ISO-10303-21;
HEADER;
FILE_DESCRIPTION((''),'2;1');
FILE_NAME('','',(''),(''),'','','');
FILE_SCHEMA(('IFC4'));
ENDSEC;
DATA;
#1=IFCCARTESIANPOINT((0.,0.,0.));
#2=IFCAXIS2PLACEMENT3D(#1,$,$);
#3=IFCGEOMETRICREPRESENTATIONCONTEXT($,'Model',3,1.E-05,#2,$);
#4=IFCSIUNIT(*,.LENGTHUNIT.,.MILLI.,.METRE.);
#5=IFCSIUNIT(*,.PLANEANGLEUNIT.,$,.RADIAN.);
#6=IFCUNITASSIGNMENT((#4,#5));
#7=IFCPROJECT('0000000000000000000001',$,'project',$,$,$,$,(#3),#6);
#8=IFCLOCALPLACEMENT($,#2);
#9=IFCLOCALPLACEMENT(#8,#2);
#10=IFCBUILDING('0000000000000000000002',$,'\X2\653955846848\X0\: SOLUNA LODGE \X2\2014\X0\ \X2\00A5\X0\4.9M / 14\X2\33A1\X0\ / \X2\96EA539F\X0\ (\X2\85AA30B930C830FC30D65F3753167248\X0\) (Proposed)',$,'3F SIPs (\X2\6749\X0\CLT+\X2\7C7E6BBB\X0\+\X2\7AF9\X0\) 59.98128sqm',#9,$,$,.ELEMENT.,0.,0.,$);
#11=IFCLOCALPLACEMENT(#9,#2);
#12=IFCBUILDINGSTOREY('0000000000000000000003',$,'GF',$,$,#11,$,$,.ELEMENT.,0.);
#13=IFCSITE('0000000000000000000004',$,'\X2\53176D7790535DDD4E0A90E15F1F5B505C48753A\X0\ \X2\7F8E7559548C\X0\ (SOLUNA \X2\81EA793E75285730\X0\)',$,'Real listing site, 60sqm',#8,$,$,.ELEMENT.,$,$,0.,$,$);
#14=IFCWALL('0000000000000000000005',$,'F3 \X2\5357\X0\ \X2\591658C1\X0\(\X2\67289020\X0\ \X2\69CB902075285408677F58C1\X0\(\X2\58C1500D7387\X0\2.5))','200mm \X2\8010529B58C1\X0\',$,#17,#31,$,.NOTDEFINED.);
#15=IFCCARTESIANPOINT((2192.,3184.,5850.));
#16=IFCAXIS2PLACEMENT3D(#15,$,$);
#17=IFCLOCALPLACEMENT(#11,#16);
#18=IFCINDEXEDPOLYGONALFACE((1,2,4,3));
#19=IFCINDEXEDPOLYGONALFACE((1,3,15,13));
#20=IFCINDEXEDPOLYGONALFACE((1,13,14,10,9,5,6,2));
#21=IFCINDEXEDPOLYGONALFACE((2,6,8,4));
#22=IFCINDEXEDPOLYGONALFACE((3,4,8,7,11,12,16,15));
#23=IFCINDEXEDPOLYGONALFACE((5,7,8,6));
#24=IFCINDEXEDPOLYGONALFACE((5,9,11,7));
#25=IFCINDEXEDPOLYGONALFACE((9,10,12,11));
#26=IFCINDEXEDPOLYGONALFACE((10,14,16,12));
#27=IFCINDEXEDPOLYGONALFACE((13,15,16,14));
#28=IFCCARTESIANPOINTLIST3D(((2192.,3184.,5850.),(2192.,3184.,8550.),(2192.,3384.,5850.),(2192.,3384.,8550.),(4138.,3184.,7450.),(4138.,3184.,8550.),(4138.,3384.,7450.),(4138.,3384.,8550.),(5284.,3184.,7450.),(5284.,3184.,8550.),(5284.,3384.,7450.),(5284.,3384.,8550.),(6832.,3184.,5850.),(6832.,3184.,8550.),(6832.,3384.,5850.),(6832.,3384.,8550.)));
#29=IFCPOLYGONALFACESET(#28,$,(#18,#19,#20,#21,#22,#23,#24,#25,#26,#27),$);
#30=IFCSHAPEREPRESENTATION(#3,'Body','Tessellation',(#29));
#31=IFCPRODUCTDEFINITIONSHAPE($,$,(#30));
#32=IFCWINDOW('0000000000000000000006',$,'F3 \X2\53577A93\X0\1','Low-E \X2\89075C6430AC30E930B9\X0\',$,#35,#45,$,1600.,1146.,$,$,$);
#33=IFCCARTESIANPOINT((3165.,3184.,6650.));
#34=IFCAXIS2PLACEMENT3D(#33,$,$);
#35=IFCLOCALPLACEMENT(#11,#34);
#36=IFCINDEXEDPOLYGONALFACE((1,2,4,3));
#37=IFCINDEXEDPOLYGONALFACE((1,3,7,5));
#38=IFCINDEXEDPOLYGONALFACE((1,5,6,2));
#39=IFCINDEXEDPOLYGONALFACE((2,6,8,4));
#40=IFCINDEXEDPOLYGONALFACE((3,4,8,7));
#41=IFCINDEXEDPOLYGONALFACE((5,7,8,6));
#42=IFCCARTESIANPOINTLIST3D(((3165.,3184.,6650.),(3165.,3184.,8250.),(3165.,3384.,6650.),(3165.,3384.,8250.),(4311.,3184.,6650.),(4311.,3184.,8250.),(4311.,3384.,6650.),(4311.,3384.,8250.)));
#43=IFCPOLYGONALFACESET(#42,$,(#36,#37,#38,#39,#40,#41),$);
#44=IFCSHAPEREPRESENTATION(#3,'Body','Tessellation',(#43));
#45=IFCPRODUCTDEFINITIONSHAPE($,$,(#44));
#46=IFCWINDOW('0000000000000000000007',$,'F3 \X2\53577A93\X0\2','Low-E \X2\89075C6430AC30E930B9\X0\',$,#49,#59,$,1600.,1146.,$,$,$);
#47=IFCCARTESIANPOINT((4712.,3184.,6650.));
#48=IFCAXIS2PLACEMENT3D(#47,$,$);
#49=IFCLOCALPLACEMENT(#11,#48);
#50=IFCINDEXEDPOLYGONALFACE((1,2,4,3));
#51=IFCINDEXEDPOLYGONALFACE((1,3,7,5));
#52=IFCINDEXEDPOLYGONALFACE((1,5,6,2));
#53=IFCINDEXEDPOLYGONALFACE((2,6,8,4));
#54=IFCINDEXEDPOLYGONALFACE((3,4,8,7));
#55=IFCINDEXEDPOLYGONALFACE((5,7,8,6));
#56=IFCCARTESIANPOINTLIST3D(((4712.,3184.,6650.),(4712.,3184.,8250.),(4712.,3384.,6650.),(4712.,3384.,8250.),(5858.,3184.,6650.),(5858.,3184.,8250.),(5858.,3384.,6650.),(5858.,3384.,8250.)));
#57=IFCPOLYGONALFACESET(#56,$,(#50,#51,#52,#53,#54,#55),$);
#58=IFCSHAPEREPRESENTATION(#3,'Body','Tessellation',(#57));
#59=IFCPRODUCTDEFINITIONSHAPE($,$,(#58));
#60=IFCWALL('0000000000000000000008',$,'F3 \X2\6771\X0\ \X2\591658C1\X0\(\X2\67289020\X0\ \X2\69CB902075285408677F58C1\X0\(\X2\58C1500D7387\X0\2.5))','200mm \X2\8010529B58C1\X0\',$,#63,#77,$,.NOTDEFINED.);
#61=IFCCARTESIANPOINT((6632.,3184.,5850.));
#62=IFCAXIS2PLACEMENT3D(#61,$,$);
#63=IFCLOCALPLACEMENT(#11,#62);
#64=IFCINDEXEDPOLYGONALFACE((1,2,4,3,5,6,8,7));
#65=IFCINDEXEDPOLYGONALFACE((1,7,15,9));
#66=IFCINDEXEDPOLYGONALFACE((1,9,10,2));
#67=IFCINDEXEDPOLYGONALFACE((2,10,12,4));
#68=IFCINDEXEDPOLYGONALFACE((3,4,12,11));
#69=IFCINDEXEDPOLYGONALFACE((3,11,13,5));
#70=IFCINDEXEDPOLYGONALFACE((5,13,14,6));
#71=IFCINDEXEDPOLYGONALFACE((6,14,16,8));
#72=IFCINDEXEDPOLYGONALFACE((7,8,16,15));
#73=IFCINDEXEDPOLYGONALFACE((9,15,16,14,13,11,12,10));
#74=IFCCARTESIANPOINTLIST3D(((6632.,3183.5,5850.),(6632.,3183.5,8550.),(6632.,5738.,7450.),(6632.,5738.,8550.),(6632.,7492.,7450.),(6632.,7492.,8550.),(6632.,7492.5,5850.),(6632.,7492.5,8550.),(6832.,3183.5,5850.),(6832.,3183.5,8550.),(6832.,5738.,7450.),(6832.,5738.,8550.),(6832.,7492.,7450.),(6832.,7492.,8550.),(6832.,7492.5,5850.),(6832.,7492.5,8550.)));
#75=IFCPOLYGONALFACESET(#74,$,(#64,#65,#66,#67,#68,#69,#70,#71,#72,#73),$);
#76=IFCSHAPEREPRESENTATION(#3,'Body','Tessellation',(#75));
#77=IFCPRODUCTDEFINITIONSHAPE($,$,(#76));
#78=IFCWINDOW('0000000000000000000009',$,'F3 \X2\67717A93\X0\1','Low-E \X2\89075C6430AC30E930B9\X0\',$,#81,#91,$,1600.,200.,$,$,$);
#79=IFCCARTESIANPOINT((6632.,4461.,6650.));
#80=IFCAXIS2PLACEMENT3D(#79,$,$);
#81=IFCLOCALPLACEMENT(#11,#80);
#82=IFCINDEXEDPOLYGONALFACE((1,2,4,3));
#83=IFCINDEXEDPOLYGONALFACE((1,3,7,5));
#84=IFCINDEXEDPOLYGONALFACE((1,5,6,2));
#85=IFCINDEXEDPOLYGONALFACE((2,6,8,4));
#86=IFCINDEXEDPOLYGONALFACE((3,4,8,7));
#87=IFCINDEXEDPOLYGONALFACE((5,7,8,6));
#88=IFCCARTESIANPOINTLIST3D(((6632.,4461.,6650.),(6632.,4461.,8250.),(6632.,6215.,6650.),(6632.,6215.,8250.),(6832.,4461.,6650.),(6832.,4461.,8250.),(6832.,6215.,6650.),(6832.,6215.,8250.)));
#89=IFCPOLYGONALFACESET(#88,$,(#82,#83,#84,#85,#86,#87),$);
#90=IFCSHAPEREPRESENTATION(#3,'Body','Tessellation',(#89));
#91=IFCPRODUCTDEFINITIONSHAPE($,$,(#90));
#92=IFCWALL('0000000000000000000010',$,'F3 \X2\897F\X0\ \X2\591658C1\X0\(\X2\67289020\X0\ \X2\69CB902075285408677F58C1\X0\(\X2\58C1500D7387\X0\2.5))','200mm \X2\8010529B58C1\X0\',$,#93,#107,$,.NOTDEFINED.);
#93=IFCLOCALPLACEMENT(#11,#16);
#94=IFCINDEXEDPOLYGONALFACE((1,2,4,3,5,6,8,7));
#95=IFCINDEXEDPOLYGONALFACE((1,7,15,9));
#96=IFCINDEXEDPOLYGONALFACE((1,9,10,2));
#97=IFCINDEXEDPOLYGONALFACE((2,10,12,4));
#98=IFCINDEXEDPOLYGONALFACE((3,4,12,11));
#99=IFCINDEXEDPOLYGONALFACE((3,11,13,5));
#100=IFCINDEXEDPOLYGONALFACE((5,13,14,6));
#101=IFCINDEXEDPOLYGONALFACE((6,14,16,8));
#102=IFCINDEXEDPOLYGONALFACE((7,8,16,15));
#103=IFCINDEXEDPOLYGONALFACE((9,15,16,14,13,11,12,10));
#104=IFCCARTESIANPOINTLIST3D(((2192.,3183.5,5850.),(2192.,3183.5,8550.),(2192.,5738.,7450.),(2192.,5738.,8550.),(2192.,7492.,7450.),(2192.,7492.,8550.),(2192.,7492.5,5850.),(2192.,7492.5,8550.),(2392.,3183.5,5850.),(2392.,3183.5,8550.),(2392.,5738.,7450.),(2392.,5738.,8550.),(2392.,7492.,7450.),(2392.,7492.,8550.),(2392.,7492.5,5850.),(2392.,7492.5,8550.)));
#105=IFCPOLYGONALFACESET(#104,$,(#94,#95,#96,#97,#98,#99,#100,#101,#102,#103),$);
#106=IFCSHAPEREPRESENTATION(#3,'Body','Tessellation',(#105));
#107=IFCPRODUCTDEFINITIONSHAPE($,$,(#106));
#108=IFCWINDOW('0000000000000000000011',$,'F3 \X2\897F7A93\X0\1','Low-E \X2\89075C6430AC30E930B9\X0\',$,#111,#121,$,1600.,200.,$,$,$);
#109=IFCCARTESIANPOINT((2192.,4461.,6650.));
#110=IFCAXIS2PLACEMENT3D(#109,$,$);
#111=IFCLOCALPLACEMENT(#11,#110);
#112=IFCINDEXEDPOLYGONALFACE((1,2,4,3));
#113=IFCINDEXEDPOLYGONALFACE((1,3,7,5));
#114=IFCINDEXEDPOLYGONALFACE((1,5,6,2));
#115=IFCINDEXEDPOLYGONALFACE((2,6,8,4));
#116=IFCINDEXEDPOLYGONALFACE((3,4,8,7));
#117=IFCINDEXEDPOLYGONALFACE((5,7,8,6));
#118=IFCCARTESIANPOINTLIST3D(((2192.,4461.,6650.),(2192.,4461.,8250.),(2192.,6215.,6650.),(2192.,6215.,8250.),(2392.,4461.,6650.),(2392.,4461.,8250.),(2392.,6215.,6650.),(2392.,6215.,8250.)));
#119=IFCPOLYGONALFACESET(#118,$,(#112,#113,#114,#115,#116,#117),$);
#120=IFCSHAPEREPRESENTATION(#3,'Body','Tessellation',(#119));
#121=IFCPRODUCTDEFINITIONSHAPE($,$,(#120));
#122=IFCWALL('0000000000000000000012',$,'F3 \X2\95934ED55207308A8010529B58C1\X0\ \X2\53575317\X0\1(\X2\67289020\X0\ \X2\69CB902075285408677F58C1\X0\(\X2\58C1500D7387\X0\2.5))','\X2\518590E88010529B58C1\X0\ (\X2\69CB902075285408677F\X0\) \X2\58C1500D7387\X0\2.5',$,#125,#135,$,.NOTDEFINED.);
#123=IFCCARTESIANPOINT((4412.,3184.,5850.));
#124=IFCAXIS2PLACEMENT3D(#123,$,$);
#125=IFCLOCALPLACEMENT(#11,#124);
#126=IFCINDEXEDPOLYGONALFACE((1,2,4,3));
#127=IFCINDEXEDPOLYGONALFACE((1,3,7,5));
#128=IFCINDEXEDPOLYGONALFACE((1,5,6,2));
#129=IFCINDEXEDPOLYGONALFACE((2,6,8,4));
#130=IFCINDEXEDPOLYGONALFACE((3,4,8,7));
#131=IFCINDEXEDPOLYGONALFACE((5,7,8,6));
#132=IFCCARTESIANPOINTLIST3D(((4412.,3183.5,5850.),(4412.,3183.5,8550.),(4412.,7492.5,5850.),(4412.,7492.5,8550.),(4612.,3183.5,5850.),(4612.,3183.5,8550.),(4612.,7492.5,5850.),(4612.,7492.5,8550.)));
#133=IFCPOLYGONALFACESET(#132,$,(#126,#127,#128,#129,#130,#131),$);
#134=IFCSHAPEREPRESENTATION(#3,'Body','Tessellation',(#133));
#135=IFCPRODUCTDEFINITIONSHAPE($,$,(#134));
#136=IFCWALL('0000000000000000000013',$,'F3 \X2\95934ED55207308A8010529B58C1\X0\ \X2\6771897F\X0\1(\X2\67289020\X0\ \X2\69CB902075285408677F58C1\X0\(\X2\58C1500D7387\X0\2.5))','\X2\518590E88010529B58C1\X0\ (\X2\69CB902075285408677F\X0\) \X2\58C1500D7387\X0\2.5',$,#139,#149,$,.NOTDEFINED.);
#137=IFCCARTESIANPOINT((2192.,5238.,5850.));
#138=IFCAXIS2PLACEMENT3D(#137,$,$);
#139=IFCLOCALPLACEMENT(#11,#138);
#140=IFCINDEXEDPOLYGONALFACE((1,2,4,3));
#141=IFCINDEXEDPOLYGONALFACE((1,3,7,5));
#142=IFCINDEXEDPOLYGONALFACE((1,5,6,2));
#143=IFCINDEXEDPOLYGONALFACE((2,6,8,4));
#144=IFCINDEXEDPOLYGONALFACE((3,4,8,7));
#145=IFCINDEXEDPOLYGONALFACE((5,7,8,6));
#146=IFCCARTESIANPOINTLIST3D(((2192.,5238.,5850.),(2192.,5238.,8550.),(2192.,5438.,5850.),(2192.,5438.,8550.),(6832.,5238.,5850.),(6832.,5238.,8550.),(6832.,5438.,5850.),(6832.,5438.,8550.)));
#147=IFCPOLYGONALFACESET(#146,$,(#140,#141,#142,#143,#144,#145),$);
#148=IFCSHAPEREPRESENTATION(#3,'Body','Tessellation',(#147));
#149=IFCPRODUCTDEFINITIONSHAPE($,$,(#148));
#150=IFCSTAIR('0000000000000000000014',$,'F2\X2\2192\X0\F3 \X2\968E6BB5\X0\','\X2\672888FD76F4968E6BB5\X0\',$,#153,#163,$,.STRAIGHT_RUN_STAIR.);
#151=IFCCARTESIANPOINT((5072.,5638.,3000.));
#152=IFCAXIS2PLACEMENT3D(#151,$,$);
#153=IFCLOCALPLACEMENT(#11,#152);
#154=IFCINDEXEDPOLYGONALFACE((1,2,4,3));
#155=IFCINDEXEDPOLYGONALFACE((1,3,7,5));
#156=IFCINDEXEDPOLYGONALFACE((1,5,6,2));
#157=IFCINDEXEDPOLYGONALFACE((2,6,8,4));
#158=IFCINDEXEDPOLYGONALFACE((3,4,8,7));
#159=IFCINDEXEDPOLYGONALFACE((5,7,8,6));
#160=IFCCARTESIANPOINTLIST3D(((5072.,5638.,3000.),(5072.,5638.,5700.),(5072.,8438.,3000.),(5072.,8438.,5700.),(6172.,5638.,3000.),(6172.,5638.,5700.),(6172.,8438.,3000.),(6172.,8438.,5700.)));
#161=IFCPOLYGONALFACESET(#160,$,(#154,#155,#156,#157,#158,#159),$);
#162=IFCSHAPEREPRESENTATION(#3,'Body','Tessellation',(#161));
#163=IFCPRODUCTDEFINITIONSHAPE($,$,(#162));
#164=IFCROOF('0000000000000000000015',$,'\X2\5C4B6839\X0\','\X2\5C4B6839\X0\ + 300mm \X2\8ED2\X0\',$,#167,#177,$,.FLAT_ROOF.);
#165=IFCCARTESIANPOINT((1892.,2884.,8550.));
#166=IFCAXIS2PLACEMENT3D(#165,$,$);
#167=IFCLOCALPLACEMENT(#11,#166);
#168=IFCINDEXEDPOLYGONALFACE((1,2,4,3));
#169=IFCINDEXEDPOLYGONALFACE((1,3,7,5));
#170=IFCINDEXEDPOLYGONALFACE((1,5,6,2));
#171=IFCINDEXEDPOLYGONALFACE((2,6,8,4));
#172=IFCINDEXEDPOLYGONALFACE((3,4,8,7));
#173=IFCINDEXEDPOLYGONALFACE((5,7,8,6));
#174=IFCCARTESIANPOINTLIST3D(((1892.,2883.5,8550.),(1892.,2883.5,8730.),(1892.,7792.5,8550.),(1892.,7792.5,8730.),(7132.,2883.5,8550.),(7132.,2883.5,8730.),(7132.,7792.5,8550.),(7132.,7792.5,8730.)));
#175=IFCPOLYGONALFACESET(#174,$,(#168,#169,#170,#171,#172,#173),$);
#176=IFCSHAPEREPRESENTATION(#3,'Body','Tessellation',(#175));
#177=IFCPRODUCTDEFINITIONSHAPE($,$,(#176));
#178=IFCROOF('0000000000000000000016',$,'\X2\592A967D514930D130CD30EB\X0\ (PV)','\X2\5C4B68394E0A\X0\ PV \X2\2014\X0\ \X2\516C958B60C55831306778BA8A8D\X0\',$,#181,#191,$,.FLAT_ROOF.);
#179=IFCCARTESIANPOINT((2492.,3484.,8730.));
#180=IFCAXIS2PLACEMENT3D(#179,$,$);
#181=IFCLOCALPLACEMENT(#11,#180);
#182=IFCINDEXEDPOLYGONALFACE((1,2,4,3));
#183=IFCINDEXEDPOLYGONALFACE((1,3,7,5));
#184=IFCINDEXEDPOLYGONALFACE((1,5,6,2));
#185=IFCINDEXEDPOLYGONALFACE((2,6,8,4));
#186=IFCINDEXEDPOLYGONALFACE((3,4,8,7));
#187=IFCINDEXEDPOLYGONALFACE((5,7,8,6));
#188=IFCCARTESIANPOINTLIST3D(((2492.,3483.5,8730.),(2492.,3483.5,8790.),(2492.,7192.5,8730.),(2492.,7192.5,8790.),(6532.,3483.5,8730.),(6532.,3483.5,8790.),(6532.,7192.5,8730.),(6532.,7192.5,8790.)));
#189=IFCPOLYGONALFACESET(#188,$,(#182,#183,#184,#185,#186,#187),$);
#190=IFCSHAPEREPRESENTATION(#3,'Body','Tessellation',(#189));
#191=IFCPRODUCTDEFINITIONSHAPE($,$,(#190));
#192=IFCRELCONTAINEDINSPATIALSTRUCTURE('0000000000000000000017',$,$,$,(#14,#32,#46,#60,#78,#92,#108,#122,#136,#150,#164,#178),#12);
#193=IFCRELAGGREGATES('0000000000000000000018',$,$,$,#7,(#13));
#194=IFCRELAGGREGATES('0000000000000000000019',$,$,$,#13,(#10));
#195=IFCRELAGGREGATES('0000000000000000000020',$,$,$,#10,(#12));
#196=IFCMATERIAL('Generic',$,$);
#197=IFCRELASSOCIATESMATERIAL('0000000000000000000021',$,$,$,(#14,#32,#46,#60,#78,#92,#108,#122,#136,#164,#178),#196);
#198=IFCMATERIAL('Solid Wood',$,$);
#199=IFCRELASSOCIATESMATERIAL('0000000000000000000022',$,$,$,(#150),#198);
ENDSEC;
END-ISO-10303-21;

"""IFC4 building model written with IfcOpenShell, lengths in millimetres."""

from ifc_helpers import new_model, si_unit, frame, frame_2d, origin, place, context, project, spatial, rectangle, extrude, material, element, fill, save


model = new_model("IFC4")

# Units and contexts
model_context = context("Model", 3, precision=1e-05, world=origin())
ifc_project = project(units=[si_unit("LENGTHUNIT", "METRE", prefix="MILLI"), si_unit("PLANEANGLEUNIT", "RADIAN")], contexts=[model_context])

# Site, building, storey
site_placement = place(None, origin())
site = spatial("IfcSite", under=ifc_project, at=site_placement, Name="北海道川上郡弟子屈町 美留和 (SOLUNA 自社用地)", ObjectType="Real listing site, 60sqm", CompositionType="ELEMENT", RefElevation=0.0)
building_placement = place(site_placement, origin())
building = spatial("IfcBuilding", under=site, at=building_placement, Name="改善案: SOLUNA LODGE — ¥4.9M / 14㎡ / 雪原 (薪ストーブ強化版) (Proposed)", ObjectType="3F SIPs (杉CLT+籾殻+竹) 59.98128sqm", CompositionType="ELEMENT", ElevationOfRefHeight=0.0, ElevationOfTerrain=0.0)
storey_placement = place(building_placement, origin())
storey = spatial("IfcBuildingStorey", under=building, at=storey_placement, Name="GF", CompositionType="ELEMENT", Elevation=0.0)

# Shared definitions
ifc_material_1 = material(Name="Generic")

# Wall, openings, windows
wall_1_placement = place(storey_placement, frame((2192.0, 3184.0, 5850.0)))
wall_1 = element("IfcWall", 1, at=wall_1_placement, inside=storey, material=ifc_material_1, Name="F3 南 外壁(木造 構造用合板壁(壁倍率2.5))", Description="200mm 耐力壁", PredefinedType="NOTDEFINED", context=model_context, shape_type="SweptSolid", body=[
    extrude(rectangle(XDim=4640.0, YDim=200.0, at=frame_2d((2320.0, 100.0))), frame((2192.0, 3184.0, 5850.0)), (0.0, 0.0, 1.0), 2700.0),
])
opening_1_placement = place(storey_placement, frame((3165.0, 3184.0, 6650.0)))
opening_1 = element("IfcOpeningElement", 2, at=opening_1_placement, cuts=wall_1, PredefinedType="NOTDEFINED", context=model_context, shape_type="SweptSolid", body=[
    extrude(rectangle(XDim=1146.0, YDim=200.0, at=frame_2d((573.0, 100.0))), frame((3165.0, 3184.0, 6650.0)), (0.0, 0.0, 1.0), 1600.0),
])
opening_2_placement = place(storey_placement, frame((4712.0, 3184.0, 6650.0)))
opening_2 = element("IfcOpeningElement", 3, at=opening_2_placement, cuts=wall_1, PredefinedType="NOTDEFINED", context=model_context, shape_type="SweptSolid", body=[
    extrude(rectangle(XDim=1146.0, YDim=200.0, at=frame_2d((573.0, 100.0))), frame((4712.0, 3184.0, 6650.0)), (0.0, 0.0, 1.0), 1600.0),
])
window_1_placement = place(storey_placement, frame((3165.0, 3184.0, 6650.0)))
window_1 = element("IfcWindow", 4, at=window_1_placement, inside=storey, material=ifc_material_1, Name="F3 南窓1", Description="Low-E 複層ガラス", OverallHeight=1600.0, OverallWidth=1146.0, context=model_context, shape_type="SweptSolid", body=[
    extrude(rectangle(XDim=1146.0, YDim=200.0, at=frame_2d((573.0, 100.0))), frame((3165.0, 3184.0, 6650.0)), (0.0, 0.0, 1.0), 1600.0),
])
fill(opening_1, window_1)
window_2_placement = place(storey_placement, frame((4712.0, 3184.0, 6650.0)))
window_2 = element("IfcWindow", 5, at=window_2_placement, inside=storey, material=ifc_material_1, Name="F3 南窓2", Description="Low-E 複層ガラス", OverallHeight=1600.0, OverallWidth=1146.0, context=model_context, shape_type="SweptSolid", body=[
    extrude(rectangle(XDim=1146.0, YDim=200.0, at=frame_2d((573.0, 100.0))), frame((4712.0, 3184.0, 6650.0)), (0.0, 0.0, 1.0), 1600.0),
])
fill(opening_2, window_2)

# Walls, openings, windows
wall_2_placement = place(storey_placement, frame((6632.0, 3184.0, 5850.0)))
wall_2 = element("IfcWall", 6, at=wall_2_placement, inside=storey, material=ifc_material_1, Name="F3 東 外壁(木造 構造用合板壁(壁倍率2.5))", Description="200mm 耐力壁", PredefinedType="NOTDEFINED", context=model_context, shape_type="SweptSolid", body=[
    extrude(rectangle(XDim=200.0, YDim=4309.0, at=frame_2d((100.0, 2154.0))), frame((6632.0, 3184.0, 5850.0)), (0.0, 0.0, 1.0), 2700.0),
])
opening_3_placement = place(storey_placement, frame((6632.0, 4461.0, 6650.0)))
opening_3 = element("IfcOpeningElement", 7, at=opening_3_placement, cuts=wall_2, PredefinedType="NOTDEFINED", context=model_context, shape_type="SweptSolid", body=[
    extrude(rectangle(XDim=200.0, YDim=1754.0, at=frame_2d((100.0, 877.0))), frame((6632.0, 4461.0, 6650.0)), (0.0, 0.0, 1.0), 1600.0),
])
window_3_placement = place(storey_placement, frame((6632.0, 4461.0, 6650.0)))
window_3 = element("IfcWindow", 8, at=window_3_placement, inside=storey, material=ifc_material_1, Name="F3 東窓1", Description="Low-E 複層ガラス", OverallHeight=1600.0, OverallWidth=200.0, context=model_context, shape_type="SweptSolid", body=[
    extrude(rectangle(XDim=200.0, YDim=1754.0, at=frame_2d((100.0, 877.0))), frame((6632.0, 4461.0, 6650.0)), (0.0, 0.0, 1.0), 1600.0),
])
fill(opening_3, window_3)
wall_3_placement = place(storey_placement, frame((2192.0, 3184.0, 5850.0)))
wall_3 = element("IfcWall", 9, at=wall_3_placement, inside=storey, material=ifc_material_1, Name="F3 西 外壁(木造 構造用合板壁(壁倍率2.5))", Description="200mm 耐力壁", PredefinedType="NOTDEFINED", context=model_context, shape_type="SweptSolid", body=[
    extrude(rectangle(XDim=200.0, YDim=4309.0, at=frame_2d((100.0, 2154.0))), frame((2192.0, 3184.0, 5850.0)), (0.0, 0.0, 1.0), 2700.0),
])
opening_4_placement = place(storey_placement, frame((2192.0, 4461.0, 6650.0)))
opening_4 = element("IfcOpeningElement", 10, at=opening_4_placement, cuts=wall_3, PredefinedType="NOTDEFINED", context=model_context, shape_type="SweptSolid", body=[
    extrude(rectangle(XDim=200.0, YDim=1754.0, at=frame_2d((100.0, 877.0))), frame((2192.0, 4461.0, 6650.0)), (0.0, 0.0, 1.0), 1600.0),
])
window_4_placement = place(storey_placement, frame((2192.0, 4461.0, 6650.0)))
window_4 = element("IfcWindow", 11, at=window_4_placement, inside=storey, material=ifc_material_1, Name="F3 西窓1", Description="Low-E 複層ガラス", OverallHeight=1600.0, OverallWidth=200.0, context=model_context, shape_type="SweptSolid", body=[
    extrude(rectangle(XDim=200.0, YDim=1754.0, at=frame_2d((100.0, 877.0))), frame((2192.0, 4461.0, 6650.0)), (0.0, 0.0, 1.0), 1600.0),
])
fill(opening_4, window_4)

# Walls
wall_4_placement = place(storey_placement, frame((4412.0, 3184.0, 5850.0)))
element("IfcWall", 12, at=wall_4_placement, inside=storey, material=ifc_material_1, Name="F3 間仕切り耐力壁 南北1(木造 構造用合板壁(壁倍率2.5))", Description="内部耐力壁 (構造用合板) 壁倍率2.5", PredefinedType="NOTDEFINED", context=model_context, shape_type="SweptSolid", body=[
    extrude(rectangle(XDim=200.0, YDim=4309.0, at=frame_2d((100.0, 2154.0))), frame((4412.0, 3184.0, 5850.0)), (0.0, 0.0, 1.0), 2700.0),
])
wall_5_placement = place(storey_placement, frame((2192.0, 5238.0, 5850.0)))
element("IfcWall", 13, at=wall_5_placement, inside=storey, material=ifc_material_1, Name="F3 間仕切り耐力壁 東西1(木造 構造用合板壁(壁倍率2.5))", Description="内部耐力壁 (構造用合板) 壁倍率2.5", PredefinedType="NOTDEFINED", context=model_context, shape_type="SweptSolid", body=[
    extrude(rectangle(XDim=4640.0, YDim=200.0, at=frame_2d((2320.0, 100.0))), frame((2192.0, 5238.0, 5850.0)), (0.0, 0.0, 1.0), 2700.0),
])

# Stair
ifc_material_2 = material(Name="Solid Wood")
stair_placement = place(storey_placement, frame((5072.0, 5638.0, 3000.0)))
element("IfcStair", 14, at=stair_placement, inside=storey, material=ifc_material_2, Name="F2→F3 階段", Description="木製直階段", PredefinedType="STRAIGHT_RUN_STAIR", context=model_context, shape_type="SweptSolid", body=[
    extrude(rectangle(XDim=1100.0, YDim=2800.0, at=frame_2d((550.0, 1400.0))), frame((5072.0, 5638.0, 3000.0)), (0.0, 0.0, 1.0), 2700.0),
])

# Roofs
roof_1_placement = place(storey_placement, frame((1892.0, 2884.0, 8550.0)))
element("IfcRoof", 15, at=roof_1_placement, inside=storey, material=ifc_material_1, Name="屋根", Description="屋根 + 300mm 軒", PredefinedType="FLAT_ROOF", context=model_context, shape_type="SweptSolid", body=[
    extrude(rectangle(XDim=5240.0, YDim=4909.0, at=frame_2d((2620.0, 2454.0))), frame((1892.0, 2884.0, 8550.0)), (0.0, 0.0, 1.0), 180.0),
])
roof_2_placement = place(storey_placement, frame((2492.0, 3484.0, 8730.0)))
element("IfcRoof", 16, at=roof_2_placement, inside=storey, material=ifc_material_1, Name="太陽光パネル (PV)", Description="屋根上 PV — 公開情報で確認", PredefinedType="FLAT_ROOF", context=model_context, shape_type="SweptSolid", body=[
    extrude(rectangle(XDim=4040.0, YDim=3709.0, at=frame_2d((2020.0, 1854.0))), frame((2492.0, 3484.0, 8730.0)), (0.0, 0.0, 1.0), 60.0),
])

save(model, "model.ifc")
